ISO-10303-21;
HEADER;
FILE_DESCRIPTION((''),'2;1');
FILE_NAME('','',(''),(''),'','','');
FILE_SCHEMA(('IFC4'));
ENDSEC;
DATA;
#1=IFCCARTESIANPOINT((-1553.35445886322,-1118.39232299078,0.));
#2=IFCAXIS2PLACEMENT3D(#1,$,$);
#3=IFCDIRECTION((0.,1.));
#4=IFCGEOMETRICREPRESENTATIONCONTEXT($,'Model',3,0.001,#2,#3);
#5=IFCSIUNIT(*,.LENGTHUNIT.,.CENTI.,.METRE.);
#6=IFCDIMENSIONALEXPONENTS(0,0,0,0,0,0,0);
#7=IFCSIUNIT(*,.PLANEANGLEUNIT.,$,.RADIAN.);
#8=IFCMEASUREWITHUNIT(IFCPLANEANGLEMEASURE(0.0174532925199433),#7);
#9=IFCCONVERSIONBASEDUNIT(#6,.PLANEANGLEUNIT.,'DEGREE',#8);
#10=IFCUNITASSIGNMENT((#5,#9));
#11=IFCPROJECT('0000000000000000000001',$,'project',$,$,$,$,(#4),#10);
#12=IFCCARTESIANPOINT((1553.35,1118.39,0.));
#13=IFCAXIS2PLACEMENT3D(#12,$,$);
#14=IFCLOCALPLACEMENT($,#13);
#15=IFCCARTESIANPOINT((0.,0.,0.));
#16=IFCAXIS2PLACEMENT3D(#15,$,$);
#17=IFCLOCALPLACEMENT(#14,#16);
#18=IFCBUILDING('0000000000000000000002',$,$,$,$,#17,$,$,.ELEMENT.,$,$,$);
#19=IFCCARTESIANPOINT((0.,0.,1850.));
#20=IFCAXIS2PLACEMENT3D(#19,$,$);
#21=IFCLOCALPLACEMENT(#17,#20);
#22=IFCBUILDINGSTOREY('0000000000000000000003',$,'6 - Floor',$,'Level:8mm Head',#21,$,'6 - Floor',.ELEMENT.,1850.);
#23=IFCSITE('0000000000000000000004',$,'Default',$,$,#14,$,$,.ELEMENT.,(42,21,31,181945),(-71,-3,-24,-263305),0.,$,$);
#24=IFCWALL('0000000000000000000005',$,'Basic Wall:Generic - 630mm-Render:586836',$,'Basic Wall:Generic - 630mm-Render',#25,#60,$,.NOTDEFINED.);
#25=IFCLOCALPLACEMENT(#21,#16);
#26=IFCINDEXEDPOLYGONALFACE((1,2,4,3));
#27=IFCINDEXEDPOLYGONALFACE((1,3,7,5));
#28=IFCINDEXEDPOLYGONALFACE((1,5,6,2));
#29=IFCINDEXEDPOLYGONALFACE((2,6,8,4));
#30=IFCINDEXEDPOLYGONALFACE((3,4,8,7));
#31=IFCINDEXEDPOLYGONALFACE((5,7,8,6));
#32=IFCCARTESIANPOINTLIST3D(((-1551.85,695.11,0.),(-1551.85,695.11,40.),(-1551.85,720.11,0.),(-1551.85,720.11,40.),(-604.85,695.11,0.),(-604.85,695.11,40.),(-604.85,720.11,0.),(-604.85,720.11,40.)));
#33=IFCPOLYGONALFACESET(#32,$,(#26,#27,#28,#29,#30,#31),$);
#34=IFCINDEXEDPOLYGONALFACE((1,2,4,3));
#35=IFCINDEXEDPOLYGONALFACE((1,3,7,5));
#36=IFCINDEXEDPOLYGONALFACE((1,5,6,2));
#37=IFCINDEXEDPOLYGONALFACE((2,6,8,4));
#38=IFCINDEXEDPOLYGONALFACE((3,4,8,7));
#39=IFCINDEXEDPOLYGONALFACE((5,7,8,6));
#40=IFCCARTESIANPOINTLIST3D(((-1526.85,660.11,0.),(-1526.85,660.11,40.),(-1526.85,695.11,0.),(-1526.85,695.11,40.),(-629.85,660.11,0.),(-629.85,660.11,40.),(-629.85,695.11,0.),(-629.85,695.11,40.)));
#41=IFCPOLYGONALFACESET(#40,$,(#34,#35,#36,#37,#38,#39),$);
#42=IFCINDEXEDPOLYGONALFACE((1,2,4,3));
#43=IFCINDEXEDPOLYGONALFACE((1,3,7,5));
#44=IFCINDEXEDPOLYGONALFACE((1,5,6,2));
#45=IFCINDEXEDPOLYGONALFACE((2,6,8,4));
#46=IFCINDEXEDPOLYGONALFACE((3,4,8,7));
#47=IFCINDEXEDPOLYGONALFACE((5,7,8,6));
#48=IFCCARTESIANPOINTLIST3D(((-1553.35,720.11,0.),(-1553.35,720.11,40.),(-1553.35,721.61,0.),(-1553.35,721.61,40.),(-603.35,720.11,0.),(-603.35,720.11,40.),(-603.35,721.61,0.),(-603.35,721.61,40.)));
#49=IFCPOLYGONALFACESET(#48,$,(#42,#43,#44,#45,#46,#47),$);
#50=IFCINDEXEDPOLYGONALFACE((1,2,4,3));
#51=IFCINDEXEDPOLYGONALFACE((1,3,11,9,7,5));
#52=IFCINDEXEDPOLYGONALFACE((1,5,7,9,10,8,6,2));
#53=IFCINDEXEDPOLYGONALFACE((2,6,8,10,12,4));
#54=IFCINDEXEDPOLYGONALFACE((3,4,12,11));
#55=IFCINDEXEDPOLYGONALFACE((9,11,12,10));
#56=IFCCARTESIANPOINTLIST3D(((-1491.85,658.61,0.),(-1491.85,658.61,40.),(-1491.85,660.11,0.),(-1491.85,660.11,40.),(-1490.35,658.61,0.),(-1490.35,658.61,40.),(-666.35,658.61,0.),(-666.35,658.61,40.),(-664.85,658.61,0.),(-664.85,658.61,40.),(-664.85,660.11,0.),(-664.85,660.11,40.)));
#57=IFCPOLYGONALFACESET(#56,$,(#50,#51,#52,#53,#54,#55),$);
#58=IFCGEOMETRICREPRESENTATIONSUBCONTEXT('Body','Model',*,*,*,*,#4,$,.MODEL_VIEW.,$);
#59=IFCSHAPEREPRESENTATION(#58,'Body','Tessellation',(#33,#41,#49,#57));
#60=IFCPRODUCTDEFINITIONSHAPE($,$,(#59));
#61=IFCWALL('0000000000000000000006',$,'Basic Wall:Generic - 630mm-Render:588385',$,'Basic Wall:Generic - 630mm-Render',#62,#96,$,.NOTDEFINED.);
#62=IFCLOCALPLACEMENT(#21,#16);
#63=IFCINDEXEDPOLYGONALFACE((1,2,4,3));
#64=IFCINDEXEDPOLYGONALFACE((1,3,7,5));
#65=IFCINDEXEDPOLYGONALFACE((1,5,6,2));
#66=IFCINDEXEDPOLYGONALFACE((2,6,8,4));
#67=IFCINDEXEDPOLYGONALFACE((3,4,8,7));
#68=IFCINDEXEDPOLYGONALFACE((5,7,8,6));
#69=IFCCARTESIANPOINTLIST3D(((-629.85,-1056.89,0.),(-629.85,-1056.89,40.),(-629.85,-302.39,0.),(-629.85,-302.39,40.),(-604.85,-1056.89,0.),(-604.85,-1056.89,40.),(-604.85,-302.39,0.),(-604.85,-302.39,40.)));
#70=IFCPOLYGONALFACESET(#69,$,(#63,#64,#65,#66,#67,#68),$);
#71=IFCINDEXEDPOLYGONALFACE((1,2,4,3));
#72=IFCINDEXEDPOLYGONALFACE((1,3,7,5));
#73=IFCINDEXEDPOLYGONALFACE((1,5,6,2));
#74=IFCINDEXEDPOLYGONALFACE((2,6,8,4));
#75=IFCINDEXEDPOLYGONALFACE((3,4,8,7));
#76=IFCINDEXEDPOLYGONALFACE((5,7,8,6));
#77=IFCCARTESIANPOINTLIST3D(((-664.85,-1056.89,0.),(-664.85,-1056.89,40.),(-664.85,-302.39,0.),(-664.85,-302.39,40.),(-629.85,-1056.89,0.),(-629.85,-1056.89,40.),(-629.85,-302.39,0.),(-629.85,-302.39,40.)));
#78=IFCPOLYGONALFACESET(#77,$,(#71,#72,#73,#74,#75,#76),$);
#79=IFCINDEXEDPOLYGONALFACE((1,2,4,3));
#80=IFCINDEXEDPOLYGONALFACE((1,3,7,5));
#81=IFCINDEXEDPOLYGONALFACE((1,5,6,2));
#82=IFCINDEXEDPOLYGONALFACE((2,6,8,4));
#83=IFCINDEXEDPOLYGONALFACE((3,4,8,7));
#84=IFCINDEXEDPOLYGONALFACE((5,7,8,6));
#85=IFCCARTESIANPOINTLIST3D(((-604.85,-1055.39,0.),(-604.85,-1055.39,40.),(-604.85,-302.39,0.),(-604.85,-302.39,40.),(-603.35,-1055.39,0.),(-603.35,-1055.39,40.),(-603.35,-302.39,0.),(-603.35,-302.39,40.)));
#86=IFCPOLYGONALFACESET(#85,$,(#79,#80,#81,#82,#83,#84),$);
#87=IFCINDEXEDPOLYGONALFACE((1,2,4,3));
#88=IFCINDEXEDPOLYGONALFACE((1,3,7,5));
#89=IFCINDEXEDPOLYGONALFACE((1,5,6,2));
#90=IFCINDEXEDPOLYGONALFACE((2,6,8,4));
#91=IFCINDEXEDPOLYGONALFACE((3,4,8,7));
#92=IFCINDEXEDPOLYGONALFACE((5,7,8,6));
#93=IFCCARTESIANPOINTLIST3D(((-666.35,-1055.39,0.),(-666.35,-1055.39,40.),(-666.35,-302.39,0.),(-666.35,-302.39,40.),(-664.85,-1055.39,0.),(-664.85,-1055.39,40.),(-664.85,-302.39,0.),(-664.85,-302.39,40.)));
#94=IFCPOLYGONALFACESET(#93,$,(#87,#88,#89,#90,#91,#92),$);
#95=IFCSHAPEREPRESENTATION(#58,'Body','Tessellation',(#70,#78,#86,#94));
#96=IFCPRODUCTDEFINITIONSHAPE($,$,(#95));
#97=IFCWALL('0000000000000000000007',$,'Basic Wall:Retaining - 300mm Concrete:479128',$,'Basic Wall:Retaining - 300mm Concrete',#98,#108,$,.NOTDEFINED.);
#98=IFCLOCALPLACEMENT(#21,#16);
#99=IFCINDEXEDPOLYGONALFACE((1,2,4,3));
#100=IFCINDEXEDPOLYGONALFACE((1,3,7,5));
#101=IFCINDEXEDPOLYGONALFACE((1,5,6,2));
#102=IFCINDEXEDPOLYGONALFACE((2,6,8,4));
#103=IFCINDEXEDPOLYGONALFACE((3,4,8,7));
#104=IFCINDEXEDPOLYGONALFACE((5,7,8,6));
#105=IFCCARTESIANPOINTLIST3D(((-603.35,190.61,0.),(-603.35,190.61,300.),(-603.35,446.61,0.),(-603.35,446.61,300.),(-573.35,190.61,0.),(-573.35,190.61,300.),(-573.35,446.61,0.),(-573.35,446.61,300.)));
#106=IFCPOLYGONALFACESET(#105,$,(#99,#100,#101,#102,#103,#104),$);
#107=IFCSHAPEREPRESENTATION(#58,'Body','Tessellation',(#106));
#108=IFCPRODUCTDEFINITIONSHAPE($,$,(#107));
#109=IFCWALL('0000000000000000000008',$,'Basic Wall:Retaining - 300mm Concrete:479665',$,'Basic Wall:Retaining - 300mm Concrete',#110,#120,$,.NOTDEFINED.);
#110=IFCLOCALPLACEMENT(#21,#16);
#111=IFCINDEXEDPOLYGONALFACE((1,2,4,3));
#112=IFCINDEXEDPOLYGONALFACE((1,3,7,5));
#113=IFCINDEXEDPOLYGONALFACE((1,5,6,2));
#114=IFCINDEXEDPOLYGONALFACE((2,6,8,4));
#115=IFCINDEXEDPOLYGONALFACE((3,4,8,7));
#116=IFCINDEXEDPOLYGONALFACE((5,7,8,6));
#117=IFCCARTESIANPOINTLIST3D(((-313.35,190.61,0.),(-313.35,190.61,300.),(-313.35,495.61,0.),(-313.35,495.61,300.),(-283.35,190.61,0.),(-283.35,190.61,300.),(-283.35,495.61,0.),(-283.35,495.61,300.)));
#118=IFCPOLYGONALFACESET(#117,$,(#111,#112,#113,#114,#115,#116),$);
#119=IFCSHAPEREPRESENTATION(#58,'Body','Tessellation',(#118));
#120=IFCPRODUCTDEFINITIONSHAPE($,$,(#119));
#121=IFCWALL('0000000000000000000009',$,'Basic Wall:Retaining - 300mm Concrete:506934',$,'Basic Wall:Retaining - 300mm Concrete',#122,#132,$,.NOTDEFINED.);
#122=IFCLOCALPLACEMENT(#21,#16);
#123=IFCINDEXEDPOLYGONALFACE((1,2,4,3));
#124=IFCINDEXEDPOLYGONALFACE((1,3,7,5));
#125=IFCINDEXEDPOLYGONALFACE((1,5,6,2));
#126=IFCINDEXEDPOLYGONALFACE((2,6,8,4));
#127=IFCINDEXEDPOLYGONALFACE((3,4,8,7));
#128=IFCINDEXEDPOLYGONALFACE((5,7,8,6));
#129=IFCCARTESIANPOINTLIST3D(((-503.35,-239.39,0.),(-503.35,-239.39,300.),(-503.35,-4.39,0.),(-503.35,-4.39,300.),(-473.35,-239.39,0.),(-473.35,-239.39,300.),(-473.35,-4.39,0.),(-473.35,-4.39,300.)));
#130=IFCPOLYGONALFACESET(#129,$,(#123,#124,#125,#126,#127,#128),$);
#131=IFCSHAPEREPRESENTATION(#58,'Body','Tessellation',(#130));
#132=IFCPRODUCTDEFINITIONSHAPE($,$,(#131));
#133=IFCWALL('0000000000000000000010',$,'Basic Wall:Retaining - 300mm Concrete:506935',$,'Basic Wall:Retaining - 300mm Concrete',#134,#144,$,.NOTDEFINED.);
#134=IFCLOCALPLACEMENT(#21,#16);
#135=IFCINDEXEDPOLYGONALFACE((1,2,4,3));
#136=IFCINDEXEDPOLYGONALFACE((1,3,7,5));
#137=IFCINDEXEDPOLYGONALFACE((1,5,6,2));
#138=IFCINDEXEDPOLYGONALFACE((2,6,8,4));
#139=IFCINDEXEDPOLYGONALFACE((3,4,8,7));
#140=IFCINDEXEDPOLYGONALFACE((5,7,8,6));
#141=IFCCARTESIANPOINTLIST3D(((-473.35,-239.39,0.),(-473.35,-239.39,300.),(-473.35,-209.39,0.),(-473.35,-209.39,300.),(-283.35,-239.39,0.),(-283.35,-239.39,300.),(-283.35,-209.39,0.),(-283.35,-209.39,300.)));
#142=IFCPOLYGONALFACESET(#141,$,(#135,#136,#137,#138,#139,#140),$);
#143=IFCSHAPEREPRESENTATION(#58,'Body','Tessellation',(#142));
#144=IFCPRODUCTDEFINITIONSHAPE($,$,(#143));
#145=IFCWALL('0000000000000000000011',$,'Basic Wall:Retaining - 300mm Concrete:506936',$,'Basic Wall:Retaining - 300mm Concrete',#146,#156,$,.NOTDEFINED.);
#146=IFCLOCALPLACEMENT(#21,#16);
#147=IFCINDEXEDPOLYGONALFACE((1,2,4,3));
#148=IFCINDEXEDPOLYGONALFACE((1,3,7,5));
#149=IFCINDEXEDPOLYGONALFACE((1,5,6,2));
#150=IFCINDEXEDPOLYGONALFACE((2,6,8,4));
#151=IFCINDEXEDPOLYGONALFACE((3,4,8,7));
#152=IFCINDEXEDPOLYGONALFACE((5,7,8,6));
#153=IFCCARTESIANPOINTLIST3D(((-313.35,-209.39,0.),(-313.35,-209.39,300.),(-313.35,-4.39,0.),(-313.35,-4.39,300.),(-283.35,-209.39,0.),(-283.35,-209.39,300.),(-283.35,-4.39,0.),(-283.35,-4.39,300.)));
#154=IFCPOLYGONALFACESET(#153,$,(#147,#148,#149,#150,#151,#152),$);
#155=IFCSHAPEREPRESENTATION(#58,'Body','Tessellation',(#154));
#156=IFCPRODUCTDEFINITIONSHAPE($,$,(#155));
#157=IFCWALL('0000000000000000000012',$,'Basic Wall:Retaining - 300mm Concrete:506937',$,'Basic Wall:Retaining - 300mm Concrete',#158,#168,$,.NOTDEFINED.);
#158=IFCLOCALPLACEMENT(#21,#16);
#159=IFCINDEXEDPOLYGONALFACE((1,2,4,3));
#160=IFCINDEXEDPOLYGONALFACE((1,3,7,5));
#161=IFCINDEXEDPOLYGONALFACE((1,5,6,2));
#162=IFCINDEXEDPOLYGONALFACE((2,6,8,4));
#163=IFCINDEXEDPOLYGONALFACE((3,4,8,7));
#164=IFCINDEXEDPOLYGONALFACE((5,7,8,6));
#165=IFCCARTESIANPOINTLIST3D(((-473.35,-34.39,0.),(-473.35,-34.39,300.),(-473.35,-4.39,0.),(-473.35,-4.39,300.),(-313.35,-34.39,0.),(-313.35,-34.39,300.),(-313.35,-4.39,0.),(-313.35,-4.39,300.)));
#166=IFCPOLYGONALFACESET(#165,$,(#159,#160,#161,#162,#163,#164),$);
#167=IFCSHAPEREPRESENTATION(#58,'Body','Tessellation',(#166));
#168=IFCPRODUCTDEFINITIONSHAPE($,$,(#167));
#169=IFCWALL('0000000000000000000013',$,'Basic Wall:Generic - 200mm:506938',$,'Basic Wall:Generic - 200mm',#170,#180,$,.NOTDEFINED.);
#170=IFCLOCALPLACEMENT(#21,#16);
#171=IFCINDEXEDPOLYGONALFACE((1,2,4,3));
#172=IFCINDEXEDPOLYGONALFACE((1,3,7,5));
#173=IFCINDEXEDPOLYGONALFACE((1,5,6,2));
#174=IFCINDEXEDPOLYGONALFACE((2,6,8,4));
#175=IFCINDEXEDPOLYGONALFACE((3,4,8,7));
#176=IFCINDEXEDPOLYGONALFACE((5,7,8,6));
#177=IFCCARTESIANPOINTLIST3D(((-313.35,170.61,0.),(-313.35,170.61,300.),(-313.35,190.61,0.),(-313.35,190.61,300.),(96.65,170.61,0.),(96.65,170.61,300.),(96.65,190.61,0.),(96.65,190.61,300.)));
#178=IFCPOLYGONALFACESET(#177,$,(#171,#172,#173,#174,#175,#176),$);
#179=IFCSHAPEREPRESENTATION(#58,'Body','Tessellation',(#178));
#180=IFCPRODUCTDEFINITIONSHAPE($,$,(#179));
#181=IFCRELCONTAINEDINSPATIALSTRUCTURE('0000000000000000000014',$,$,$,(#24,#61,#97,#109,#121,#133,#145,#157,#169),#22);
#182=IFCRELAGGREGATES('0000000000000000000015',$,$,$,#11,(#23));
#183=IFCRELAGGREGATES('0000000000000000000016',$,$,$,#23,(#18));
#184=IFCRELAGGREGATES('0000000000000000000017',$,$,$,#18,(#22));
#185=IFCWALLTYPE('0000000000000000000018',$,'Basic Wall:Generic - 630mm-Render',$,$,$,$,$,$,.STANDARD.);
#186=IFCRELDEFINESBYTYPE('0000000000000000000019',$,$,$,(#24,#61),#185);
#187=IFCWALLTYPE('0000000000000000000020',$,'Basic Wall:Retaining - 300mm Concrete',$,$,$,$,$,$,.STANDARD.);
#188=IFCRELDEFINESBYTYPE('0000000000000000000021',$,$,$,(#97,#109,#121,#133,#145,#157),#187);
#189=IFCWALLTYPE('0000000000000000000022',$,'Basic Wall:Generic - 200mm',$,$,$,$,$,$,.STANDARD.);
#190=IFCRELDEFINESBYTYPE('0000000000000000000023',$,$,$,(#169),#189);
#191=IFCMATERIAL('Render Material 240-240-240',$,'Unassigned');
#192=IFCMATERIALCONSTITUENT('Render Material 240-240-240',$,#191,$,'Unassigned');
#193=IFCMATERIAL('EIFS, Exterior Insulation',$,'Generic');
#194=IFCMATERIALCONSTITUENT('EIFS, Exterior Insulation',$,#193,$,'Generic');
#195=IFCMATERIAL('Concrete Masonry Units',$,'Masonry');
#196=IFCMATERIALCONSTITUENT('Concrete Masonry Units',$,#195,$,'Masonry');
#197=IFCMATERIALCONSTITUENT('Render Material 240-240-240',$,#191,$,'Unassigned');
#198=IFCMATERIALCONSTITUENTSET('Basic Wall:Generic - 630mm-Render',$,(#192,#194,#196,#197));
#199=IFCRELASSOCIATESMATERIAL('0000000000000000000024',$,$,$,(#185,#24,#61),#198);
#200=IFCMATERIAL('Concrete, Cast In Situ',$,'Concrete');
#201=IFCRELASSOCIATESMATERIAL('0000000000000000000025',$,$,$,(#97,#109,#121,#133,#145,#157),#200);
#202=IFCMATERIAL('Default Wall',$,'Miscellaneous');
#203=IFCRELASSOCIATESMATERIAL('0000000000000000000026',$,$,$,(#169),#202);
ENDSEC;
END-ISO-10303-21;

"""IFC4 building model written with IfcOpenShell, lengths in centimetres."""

from ifc_helpers import new_model, entity, si_unit, converted_unit, direction, frame, origin, place, context, subcontext, project, spatial, indexed_curve, outline, extrude, material, constituent, constituent_set, type_object, element, save


model = new_model("IFC4")

# Units and contexts
model_context = context("Model", 3, precision=0.001, world=frame((-1553.35445886322, -1118.39232299078, 0.0)), true_north=direction((0.0, 1.0)))
body_context = subcontext(model_context, "Body", "Model", "MODEL_VIEW")
ifc_project = project(units=[si_unit("LENGTHUNIT", "METRE", prefix="CENTI"), converted_unit("PLANEANGLEUNIT", "DEGREE", entity("IfcPlaneAngleMeasure", 0.0174532925199433), si_unit("PLANEANGLEUNIT", "RADIAN"), dimensions=[0, 0, 0, 0, 0, 0, 0])], contexts=[model_context])

# Site, building, storey
site_placement = place(None, frame((1553.35, 1118.39, 0.0)))
site = spatial("IfcSite", under=ifc_project, at=site_placement, Name="Default", CompositionType="ELEMENT", RefLatitude=(42, 21, 31, 181945), RefLongitude=(-71, -3, -24, -263305), RefElevation=0.0)
building_placement = place(site_placement, origin())
building = spatial("IfcBuilding", under=site, at=building_placement, CompositionType="ELEMENT")
storey_placement = place(building_placement, frame((0.0, 0.0, 1850.0)))
storey = spatial("IfcBuildingStorey", under=building, at=storey_placement, Name="6 - Floor", ObjectType="Level:8mm Head", LongName="6 - Floor", CompositionType="ELEMENT", Elevation=1850.0)

# Walls
ifc_material_1 = material(Name="Render Material 240-240-240", Category="Unassigned")
ifc_constituent_1 = constituent(ifc_material_1, Name="Render Material 240-240-240", Category="Unassigned")
ifc_material_2 = material(Name="EIFS, Exterior Insulation", Category="Generic")
ifc_constituent_2 = constituent(ifc_material_2, Name="EIFS, Exterior Insulation", Category="Generic")
ifc_material_3 = material(Name="Concrete Masonry Units", Category="Masonry")
ifc_constituent_3 = constituent(ifc_material_3, Name="Concrete Masonry Units", Category="Masonry")
ifc_constituent_4 = constituent(ifc_material_1, Name="Render Material 240-240-240", Category="Unassigned")
ifc_constituent_set_1 = constituent_set(constituents=[ifc_constituent_1, ifc_constituent_2, ifc_constituent_3, ifc_constituent_4], Name="Basic Wall:Generic - 630mm-Render")
wall_type_1 = type_object("IfcWallType", Name="Basic Wall:Generic - 630mm-Render", PredefinedType="STANDARD", material=ifc_constituent_set_1)
wall_1_placement = place(storey_placement, frame((-1553.35, 690.11, 0.0)))
element("IfcWall", 1, at=wall_1_placement, inside=storey, type_object=wall_type_1, material=ifc_constituent_set_1, Name="Basic Wall:Generic - 630mm-Render:586836", ObjectType="Basic Wall:Generic - 630mm-Render", PredefinedType="NOTDEFINED", context=body_context, shape_type="SweptSolid", body=[
    extrude(outline(indexed_curve([(-473.5, -12.5), (473.5, -12.5), (473.5, 12.5), (-473.5, 12.5), (-473.5, -12.5)], self_intersect=False)), frame((475.0, 17.5, 0.0)), (0.0, 0.0, 1.0), 40.0),
    extrude(outline(indexed_curve([(-448.5, -17.5), (448.5, -17.5), (448.5, 17.5), (-448.5, 17.5), (-448.5, -17.5)], self_intersect=False)), frame((475.0, -12.5, 0.0)), (0.0, 0.0, 1.0), 40.0),
    extrude(outline(indexed_curve([(-0.75, -475.0), (0.75, -475.0), (0.75, 475.0), (-0.75, 475.0), (-0.75, -475.0)], self_intersect=False)), frame((475.0, 30.75, 0.0), z_axis=(0.0, 0.0, 1.0), x_axis=(0.0, -1.0, 0.0)), (0.0, 0.0, 1.0), 40.0),
    extrude(outline(indexed_curve([(-412.0, -0.5), (412.0, -0.5), (413.5, -0.5), (413.5, 1.0), (-413.5, 1.0), (-413.5, -0.5), (-412.0, -0.5)], self_intersect=False)), frame((475.0, -31.0, 0.0)), (0.0, 0.0, 1.0), 40.0),
])
wall_2_placement = place(storey_placement, frame((-634.85, -1055.39, 0.0), z_axis=(0.0, 0.0, 1.0), x_axis=(0.0, 1.0, 0.0)))
element("IfcWall", 2, at=wall_2_placement, inside=storey, type_object=wall_type_1, material=ifc_constituent_set_1, Name="Basic Wall:Generic - 630mm-Render:588385", ObjectType="Basic Wall:Generic - 630mm-Render", PredefinedType="NOTDEFINED", context=body_context, shape_type="SweptSolid", body=[
    extrude(outline(indexed_curve([(-377.25, -12.5), (377.25, -12.5), (377.25, 12.5), (-377.25, 12.5), (-377.25, -12.5)], self_intersect=False)), frame((375.75, -17.5, 0.0)), (0.0, 0.0, 1.0), 40.0),
    extrude(outline(indexed_curve([(-377.25, -17.5), (377.25, -17.5), (377.25, 17.5), (-377.25, 17.5), (-377.25, -17.5)], self_intersect=False)), frame((375.75, 12.5, 0.0)), (0.0, 0.0, 1.0), 40.0),
    extrude(outline(indexed_curve([(-0.75, -376.5), (0.75, -376.5), (0.75, 376.5), (-0.75, 376.5), (-0.75, -376.5)], self_intersect=False)), frame((376.5, -30.75, 0.0), z_axis=(0.0, 0.0, 1.0), x_axis=(0.0, 1.0, 0.0)), (0.0, 0.0, 1.0), 40.0),
    extrude(outline(indexed_curve([(-0.75, -376.5), (0.75, -376.5), (0.75, 376.5), (-0.75, 376.5), (-0.75, -376.5)], self_intersect=False)), frame((376.5, 30.75, 0.0), z_axis=(0.0, 0.0, 1.0), x_axis=(0.0, -1.0, 0.0)), (0.0, 0.0, 1.0), 40.0),
])
ifc_material_4 = material(Name="Concrete, Cast In Situ", Category="Concrete")
wall_type_2 = type_object("IfcWallType", Name="Basic Wall:Retaining - 300mm Concrete", PredefinedType="STANDARD")
wall_3_placement = place(storey_placement, frame((-588.35, 446.61, 0.0), z_axis=(0.0, 0.0, 1.0), x_axis=(0.0, -1.0, 0.0)))
element("IfcWall", 3, at=wall_3_placement, inside=storey, type_object=wall_type_2, material=ifc_material_4, Name="Basic Wall:Retaining - 300mm Concrete:479128", ObjectType="Basic Wall:Retaining - 300mm Concrete", PredefinedType="NOTDEFINED", context=body_context, shape_type="SweptSolid", body=[
    extrude(outline(indexed_curve([(256.0, 15.0), (0.0, 15.0), (0.0, -15.0), (256.0, -15.0), (256.0, 15.0)], self_intersect=False)), origin(), (0.0, 0.0, 1.0), 300.0),
])
wall_4_placement = place(storey_placement, frame((-298.35, 495.61, 0.0), z_axis=(0.0, 0.0, 1.0), x_axis=(0.0, -1.0, 0.0)))
element("IfcWall", 4, at=wall_4_placement, inside=storey, type_object=wall_type_2, material=ifc_material_4, Name="Basic Wall:Retaining - 300mm Concrete:479665", ObjectType="Basic Wall:Retaining - 300mm Concrete", PredefinedType="NOTDEFINED", context=body_context, shape_type="SweptSolid", body=[
    extrude(outline(indexed_curve([(305.0, 15.0), (0.0, 15.0), (0.0, -15.0), (305.0, -15.0), (305.0, 15.0)], self_intersect=False)), origin(), (0.0, 0.0, 1.0), 300.0),
])
wall_5_placement = place(storey_placement, frame((-488.35, -4.39, 0.0), z_axis=(0.0, 0.0, 1.0), x_axis=(0.0, -1.0, 0.0)))
element("IfcWall", 5, at=wall_5_placement, inside=storey, type_object=wall_type_2, material=ifc_material_4, Name="Basic Wall:Retaining - 300mm Concrete:506934", ObjectType="Basic Wall:Retaining - 300mm Concrete", PredefinedType="NOTDEFINED", context=body_context, shape_type="SweptSolid", body=[
    extrude(outline(indexed_curve([(235.0, 15.0), (0.0, 15.0), (0.0, -15.0), (235.0, -15.0), (235.0, 15.0)], self_intersect=False)), origin(), (0.0, 0.0, 1.0), 300.0),
])
wall_6_placement = place(storey_placement, frame((-473.35, -224.39, 0.0)))
element("IfcWall", 6, at=wall_6_placement, inside=storey, type_object=wall_type_2, material=ifc_material_4, Name="Basic Wall:Retaining - 300mm Concrete:506935", ObjectType="Basic Wall:Retaining - 300mm Concrete", PredefinedType="NOTDEFINED", context=body_context, shape_type="SweptSolid", body=[
    extrude(outline(indexed_curve([(190.0, 15.0), (0.0, 15.0), (0.0, -15.0), (190.0, -15.0), (190.0, 15.0)], self_intersect=False)), origin(), (0.0, 0.0, 1.0), 300.0),
])
wall_7_placement = place(storey_placement, frame((-298.35, -209.39, 0.0), z_axis=(0.0, 0.0, 1.0), x_axis=(0.0, 1.0, 0.0)))
element("IfcWall", 7, at=wall_7_placement, inside=storey, type_object=wall_type_2, material=ifc_material_4, Name="Basic Wall:Retaining - 300mm Concrete:506936", ObjectType="Basic Wall:Retaining - 300mm Concrete", PredefinedType="NOTDEFINED", context=body_context, shape_type="SweptSolid", body=[
    extrude(outline(indexed_curve([(205.0, 15.0), (0.0, 15.0), (0.0, -15.0), (205.0, -15.0), (205.0, 15.0)], self_intersect=False)), origin(), (0.0, 0.0, 1.0), 300.0),
])
wall_8_placement = place(storey_placement, frame((-313.35, -19.39, 0.0), z_axis=(0.0, 0.0, 1.0), x_axis=(-1.0, 0.0, 0.0)))
element("IfcWall", 8, at=wall_8_placement, inside=storey, type_object=wall_type_2, material=ifc_material_4, Name="Basic Wall:Retaining - 300mm Concrete:506937", ObjectType="Basic Wall:Retaining - 300mm Concrete", PredefinedType="NOTDEFINED", context=body_context, shape_type="SweptSolid", body=[
    extrude(outline(indexed_curve([(160.0, 15.0), (0.0, 15.0), (0.0, -15.0), (160.0, -15.0), (160.0, 15.0)], self_intersect=False)), origin(), (0.0, 0.0, 1.0), 300.0),
])
ifc_material_5 = material(Name="Default Wall", Category="Miscellaneous")
wall_type_3 = type_object("IfcWallType", Name="Basic Wall:Generic - 200mm", PredefinedType="STANDARD")
wall_9_placement = place(storey_placement, frame((-313.35, 180.61, 0.0)))
element("IfcWall", 9, at=wall_9_placement, inside=storey, type_object=wall_type_3, material=ifc_material_5, Name="Basic Wall:Generic - 200mm:506938", ObjectType="Basic Wall:Generic - 200mm", PredefinedType="NOTDEFINED", context=body_context, shape_type="SweptSolid", body=[
    extrude(outline(indexed_curve([(410.0, 10.0), (0.0, 10.0), (0.0, -10.0), (410.0, -10.0), (410.0, 10.0)], self_intersect=False)), origin(), (0.0, 0.0, 1.0), 300.0),
])

save(model, "model.ifc")
